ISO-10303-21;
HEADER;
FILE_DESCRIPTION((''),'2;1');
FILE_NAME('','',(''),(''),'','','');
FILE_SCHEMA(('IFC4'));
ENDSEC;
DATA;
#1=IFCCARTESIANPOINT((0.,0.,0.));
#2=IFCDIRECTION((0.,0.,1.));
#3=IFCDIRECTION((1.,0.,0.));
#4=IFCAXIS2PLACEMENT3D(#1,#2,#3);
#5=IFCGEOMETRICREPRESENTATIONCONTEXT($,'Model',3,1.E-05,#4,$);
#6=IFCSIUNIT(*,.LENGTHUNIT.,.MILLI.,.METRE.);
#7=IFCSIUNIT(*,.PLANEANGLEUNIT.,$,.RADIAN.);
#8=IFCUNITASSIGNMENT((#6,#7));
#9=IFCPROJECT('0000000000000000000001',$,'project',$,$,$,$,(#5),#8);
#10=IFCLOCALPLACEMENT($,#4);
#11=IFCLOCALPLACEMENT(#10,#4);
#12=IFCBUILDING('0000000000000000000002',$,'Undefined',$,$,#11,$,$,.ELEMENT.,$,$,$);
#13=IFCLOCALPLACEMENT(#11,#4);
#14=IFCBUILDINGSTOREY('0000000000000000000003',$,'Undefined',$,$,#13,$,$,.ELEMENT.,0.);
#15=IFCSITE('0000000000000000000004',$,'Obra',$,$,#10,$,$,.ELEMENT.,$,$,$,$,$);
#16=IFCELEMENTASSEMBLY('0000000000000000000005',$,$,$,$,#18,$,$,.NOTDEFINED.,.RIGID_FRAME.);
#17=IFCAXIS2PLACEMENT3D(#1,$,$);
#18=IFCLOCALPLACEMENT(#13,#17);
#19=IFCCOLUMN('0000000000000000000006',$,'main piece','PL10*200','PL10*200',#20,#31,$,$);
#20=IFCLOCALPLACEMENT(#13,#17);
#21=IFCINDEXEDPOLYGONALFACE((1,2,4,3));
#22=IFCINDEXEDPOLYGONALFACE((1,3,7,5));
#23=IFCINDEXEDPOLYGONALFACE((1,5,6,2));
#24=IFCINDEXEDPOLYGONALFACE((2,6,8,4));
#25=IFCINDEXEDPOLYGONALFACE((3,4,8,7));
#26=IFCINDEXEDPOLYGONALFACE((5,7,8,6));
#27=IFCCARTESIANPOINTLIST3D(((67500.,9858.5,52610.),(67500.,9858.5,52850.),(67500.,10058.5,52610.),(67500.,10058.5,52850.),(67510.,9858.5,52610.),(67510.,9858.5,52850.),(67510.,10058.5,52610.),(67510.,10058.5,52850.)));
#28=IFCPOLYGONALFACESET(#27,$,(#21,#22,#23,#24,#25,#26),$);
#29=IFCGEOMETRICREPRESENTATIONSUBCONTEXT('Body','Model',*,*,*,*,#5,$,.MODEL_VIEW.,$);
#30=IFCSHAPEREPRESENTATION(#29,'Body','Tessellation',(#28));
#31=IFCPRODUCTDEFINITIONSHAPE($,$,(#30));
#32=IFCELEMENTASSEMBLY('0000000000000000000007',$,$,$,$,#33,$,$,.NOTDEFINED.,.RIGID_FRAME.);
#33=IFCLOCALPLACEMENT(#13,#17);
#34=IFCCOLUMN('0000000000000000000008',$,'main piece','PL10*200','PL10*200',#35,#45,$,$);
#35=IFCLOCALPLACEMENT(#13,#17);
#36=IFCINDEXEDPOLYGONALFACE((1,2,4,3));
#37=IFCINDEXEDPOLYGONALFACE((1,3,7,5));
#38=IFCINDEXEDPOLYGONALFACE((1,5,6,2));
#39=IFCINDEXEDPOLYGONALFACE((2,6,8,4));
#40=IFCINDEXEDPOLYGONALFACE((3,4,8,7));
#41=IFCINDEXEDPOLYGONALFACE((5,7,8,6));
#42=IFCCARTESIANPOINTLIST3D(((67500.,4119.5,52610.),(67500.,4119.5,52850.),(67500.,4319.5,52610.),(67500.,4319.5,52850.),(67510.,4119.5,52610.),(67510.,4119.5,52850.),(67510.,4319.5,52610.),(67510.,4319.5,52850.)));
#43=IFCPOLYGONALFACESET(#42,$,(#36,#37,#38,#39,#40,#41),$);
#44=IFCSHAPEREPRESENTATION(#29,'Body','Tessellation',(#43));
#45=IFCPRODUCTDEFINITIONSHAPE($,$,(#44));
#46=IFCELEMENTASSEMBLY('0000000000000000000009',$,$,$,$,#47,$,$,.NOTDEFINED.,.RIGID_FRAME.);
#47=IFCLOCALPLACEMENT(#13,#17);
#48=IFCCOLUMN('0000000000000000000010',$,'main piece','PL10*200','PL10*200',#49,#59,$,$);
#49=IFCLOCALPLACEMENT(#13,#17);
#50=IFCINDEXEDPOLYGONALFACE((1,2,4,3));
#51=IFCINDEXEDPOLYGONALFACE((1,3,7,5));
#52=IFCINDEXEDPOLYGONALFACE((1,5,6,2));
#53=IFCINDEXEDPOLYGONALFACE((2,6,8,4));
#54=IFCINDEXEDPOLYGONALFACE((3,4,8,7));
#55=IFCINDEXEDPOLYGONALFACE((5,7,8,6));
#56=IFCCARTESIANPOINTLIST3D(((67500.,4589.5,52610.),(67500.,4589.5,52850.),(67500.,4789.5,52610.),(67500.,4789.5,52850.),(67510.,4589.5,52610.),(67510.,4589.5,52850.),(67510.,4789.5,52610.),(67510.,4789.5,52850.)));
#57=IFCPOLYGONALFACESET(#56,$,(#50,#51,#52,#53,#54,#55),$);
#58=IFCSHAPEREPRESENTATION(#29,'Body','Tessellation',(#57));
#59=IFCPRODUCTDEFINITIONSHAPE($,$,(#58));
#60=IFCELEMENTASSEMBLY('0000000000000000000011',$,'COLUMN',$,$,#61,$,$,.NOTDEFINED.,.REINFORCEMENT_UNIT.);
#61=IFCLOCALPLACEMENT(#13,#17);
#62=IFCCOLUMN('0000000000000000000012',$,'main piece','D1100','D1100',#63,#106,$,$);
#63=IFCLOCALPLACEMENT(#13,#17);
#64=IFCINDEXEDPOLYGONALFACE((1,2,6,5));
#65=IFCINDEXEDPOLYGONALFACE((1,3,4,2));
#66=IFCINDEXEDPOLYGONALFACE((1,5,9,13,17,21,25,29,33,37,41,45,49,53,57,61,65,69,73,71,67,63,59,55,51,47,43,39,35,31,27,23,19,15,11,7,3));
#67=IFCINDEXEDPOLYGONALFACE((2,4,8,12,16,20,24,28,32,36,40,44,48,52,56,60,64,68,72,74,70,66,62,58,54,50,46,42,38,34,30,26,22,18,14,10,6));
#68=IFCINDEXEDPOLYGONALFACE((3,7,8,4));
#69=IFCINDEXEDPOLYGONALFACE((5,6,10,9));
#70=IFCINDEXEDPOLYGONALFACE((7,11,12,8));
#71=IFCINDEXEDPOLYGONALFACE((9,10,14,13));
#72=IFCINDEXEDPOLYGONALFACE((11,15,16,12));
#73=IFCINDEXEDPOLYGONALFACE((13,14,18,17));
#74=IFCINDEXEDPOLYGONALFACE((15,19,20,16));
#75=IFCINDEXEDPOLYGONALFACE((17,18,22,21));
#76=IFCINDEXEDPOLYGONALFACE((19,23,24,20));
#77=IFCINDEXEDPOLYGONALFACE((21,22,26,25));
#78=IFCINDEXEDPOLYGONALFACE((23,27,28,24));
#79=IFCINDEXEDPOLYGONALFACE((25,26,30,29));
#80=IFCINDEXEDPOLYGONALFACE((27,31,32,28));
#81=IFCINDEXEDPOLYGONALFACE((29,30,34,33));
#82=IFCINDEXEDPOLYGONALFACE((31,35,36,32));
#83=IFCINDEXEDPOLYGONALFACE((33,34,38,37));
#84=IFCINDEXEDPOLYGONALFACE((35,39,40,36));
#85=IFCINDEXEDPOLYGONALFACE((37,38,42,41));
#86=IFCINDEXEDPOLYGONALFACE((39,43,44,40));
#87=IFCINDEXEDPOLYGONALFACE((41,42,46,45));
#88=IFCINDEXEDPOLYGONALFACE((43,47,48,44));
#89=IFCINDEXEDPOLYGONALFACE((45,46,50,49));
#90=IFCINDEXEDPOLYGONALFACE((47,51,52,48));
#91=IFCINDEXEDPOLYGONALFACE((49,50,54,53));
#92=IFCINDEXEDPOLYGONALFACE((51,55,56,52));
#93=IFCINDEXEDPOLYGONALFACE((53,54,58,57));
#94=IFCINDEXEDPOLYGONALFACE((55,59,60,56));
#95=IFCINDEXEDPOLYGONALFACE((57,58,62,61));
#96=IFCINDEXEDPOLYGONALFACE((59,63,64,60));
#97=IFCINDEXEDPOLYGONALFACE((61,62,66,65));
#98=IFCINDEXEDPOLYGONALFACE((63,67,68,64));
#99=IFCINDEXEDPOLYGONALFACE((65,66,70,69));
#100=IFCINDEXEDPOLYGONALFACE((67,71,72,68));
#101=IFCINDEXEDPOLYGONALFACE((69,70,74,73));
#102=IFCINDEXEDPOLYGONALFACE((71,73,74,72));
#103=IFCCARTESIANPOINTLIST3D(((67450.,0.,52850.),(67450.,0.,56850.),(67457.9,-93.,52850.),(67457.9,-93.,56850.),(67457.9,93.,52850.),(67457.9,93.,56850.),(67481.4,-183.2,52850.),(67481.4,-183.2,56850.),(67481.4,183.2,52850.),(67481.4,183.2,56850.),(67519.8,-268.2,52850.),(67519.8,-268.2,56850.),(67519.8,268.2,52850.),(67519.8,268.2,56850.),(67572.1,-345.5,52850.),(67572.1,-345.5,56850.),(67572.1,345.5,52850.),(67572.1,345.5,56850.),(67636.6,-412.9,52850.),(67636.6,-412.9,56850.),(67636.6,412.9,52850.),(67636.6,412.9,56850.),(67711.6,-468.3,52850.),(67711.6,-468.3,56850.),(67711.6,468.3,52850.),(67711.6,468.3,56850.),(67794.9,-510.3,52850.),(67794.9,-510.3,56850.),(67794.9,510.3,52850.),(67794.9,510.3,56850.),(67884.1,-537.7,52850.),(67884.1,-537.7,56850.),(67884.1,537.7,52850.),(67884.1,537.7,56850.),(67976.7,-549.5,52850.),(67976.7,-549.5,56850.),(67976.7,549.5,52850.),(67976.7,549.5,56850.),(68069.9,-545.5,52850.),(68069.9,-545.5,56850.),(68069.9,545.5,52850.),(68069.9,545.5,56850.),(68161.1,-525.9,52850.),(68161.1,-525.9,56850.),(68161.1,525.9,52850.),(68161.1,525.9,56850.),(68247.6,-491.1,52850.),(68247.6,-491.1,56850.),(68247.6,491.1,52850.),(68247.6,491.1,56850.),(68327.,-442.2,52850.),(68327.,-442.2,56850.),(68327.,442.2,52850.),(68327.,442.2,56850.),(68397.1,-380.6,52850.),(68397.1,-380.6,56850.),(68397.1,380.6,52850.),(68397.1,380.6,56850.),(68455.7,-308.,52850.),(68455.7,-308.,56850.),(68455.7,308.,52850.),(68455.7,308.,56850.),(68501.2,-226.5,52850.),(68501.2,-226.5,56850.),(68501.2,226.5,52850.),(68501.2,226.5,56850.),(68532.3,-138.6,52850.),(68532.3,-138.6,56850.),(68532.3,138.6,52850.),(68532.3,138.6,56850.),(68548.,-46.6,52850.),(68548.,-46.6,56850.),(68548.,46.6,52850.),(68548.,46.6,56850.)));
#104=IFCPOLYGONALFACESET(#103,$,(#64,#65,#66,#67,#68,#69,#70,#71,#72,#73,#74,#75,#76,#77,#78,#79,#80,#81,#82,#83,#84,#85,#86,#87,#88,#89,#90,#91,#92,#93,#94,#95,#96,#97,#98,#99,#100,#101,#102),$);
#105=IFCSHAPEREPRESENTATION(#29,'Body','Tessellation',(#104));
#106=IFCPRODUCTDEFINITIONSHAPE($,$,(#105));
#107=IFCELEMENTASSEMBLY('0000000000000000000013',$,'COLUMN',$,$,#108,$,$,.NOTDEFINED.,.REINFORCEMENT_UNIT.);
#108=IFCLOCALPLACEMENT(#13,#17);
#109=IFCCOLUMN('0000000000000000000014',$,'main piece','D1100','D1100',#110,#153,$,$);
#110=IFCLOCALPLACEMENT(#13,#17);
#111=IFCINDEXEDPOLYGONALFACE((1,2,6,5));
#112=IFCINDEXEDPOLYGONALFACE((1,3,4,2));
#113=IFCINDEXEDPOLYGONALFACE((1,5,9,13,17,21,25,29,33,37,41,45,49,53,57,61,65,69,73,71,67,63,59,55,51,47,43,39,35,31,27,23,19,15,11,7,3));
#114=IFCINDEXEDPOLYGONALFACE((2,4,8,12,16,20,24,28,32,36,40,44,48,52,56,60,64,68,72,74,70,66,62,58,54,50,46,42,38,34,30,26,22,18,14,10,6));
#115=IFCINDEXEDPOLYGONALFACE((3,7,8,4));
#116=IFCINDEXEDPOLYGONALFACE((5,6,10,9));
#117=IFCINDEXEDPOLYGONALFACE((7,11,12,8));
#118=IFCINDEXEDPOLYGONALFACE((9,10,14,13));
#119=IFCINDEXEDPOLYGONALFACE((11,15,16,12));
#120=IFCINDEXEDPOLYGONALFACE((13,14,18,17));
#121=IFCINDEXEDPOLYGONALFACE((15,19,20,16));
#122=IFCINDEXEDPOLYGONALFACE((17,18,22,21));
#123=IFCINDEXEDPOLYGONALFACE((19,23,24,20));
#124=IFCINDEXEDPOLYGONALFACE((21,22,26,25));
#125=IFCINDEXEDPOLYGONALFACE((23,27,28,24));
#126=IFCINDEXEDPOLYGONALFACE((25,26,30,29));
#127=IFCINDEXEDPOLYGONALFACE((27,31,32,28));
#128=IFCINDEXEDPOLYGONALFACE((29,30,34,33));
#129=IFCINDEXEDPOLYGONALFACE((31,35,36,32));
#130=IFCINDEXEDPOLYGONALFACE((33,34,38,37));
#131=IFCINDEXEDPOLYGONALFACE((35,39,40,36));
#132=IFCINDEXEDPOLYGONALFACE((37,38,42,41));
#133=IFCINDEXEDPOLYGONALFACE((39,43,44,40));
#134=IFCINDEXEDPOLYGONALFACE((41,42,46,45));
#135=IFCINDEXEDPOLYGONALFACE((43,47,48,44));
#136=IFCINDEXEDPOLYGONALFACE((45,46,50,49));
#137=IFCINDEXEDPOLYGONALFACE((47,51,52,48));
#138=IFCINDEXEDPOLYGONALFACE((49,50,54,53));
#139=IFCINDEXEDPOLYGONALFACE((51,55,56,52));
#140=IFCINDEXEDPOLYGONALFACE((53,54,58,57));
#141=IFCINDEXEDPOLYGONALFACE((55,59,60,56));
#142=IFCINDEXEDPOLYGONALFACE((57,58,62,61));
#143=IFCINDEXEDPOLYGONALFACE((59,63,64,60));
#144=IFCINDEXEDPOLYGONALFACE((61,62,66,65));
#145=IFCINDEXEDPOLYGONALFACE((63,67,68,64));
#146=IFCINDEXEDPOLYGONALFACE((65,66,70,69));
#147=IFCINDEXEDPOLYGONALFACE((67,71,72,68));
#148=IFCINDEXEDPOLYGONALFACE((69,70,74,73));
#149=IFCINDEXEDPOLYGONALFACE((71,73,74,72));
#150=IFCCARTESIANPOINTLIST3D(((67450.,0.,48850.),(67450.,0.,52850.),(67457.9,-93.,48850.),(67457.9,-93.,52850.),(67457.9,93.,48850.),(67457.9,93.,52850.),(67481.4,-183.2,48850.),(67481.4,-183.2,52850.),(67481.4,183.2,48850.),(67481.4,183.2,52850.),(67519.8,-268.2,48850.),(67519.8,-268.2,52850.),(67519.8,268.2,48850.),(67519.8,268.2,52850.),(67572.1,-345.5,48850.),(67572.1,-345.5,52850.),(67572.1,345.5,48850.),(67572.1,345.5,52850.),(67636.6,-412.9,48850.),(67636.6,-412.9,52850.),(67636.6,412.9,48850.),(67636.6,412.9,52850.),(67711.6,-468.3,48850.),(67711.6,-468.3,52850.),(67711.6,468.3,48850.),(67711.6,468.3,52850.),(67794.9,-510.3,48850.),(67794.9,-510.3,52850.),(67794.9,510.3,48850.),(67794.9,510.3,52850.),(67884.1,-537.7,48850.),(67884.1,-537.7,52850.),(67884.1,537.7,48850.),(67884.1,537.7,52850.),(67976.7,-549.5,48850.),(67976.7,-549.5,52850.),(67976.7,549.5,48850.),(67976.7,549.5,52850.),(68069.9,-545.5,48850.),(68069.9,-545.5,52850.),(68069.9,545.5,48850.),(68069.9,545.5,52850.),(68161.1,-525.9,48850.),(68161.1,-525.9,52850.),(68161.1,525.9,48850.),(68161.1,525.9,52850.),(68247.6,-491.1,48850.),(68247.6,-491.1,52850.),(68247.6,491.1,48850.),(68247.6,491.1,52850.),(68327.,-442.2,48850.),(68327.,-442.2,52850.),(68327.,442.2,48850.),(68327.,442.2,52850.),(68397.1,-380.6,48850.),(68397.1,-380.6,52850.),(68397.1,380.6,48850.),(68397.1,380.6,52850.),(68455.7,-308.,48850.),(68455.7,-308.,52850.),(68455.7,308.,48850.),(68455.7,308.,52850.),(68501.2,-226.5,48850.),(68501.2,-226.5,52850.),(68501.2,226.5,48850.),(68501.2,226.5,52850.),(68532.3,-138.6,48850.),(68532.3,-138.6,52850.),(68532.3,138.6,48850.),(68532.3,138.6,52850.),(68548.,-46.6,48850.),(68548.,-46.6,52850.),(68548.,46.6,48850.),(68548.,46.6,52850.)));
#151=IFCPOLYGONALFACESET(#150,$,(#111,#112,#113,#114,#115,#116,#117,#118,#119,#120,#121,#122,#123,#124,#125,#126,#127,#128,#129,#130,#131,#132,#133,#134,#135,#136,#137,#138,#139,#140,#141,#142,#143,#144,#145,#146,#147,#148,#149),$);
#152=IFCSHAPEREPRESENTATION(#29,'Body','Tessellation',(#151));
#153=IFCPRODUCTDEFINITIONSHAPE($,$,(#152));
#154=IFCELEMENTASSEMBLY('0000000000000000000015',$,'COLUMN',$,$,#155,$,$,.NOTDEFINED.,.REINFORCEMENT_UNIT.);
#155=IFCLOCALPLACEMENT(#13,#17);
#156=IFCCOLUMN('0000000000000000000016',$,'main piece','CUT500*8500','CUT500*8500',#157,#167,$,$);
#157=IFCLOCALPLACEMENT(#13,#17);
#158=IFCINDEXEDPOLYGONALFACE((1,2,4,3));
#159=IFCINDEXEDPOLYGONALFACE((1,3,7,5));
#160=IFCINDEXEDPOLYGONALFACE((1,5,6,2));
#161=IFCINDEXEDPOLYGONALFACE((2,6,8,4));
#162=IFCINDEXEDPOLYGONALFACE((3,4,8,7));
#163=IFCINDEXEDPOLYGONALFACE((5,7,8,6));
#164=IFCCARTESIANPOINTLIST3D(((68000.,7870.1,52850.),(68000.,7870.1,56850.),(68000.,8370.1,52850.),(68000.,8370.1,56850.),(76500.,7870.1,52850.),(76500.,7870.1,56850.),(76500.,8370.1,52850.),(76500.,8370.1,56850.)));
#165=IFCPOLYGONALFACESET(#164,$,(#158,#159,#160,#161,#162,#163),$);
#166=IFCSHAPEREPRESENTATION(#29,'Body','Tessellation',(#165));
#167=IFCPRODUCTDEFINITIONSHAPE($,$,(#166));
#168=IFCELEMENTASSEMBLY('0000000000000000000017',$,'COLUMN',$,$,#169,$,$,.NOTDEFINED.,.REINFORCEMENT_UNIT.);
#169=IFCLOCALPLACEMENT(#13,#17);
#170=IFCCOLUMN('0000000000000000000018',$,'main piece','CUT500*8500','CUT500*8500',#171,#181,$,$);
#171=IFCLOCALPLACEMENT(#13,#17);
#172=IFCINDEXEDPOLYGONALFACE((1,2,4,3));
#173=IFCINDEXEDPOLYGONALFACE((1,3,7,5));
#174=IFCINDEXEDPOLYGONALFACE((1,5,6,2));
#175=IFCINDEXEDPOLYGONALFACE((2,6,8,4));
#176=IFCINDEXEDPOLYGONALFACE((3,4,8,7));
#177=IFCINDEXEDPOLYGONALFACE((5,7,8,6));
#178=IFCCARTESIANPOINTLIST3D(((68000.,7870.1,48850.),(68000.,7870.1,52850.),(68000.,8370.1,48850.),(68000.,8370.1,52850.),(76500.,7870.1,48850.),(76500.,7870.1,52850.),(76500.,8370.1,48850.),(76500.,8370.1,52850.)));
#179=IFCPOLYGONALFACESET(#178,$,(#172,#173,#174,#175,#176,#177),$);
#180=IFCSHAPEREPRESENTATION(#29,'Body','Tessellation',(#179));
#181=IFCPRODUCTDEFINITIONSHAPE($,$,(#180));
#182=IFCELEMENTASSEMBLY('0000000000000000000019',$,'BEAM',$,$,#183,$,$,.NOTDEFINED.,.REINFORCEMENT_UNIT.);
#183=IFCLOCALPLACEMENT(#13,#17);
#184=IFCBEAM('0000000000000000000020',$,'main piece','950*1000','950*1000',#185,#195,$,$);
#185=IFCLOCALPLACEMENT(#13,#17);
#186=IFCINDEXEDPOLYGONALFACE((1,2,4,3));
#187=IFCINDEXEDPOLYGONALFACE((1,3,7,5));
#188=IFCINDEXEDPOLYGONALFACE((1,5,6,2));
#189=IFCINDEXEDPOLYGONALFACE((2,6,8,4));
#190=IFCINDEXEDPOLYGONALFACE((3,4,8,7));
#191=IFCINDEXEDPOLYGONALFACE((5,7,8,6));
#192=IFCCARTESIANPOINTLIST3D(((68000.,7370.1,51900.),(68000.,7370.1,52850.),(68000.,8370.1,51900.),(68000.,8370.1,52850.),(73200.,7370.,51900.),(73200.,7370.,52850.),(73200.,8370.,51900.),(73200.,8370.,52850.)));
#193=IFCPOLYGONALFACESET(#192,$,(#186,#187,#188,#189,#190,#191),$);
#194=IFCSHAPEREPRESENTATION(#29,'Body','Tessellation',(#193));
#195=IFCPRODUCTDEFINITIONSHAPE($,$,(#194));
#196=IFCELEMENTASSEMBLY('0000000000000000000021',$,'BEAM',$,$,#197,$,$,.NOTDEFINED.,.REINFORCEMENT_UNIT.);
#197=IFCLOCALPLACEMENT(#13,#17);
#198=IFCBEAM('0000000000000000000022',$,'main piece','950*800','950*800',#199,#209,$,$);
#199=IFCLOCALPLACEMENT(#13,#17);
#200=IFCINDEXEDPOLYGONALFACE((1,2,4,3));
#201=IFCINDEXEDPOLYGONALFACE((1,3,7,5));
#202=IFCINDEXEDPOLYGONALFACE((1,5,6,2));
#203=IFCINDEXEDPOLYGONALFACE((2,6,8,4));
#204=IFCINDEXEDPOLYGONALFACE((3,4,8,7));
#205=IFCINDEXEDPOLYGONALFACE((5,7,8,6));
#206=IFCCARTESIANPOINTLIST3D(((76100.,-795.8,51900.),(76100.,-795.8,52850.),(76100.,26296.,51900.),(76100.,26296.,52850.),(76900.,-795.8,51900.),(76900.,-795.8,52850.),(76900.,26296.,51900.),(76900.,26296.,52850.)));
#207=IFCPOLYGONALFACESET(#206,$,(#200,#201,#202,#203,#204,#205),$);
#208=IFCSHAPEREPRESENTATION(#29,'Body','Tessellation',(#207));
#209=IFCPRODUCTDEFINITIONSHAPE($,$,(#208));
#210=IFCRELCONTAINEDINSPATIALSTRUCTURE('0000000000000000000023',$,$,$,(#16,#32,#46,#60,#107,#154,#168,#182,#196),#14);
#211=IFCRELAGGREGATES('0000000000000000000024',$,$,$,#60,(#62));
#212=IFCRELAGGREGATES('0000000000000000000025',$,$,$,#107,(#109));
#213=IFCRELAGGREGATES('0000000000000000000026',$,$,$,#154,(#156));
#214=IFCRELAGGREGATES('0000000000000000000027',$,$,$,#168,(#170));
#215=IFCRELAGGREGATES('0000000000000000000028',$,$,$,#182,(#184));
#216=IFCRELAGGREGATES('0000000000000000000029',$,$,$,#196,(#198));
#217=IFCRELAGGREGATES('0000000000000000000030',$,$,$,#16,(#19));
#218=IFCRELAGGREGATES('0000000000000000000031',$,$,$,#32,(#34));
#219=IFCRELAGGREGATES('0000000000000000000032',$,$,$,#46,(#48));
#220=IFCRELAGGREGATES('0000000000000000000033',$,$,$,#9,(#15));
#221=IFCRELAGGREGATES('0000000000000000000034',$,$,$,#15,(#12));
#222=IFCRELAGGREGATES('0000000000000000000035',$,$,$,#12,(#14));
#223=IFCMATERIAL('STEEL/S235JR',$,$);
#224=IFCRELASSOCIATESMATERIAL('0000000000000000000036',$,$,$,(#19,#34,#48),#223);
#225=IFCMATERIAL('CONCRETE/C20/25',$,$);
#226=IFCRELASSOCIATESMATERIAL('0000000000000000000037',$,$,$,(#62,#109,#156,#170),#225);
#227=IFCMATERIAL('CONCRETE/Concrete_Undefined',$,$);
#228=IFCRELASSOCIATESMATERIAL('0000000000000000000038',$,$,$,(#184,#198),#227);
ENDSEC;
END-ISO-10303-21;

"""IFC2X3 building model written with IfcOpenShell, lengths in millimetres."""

from ifc_helpers import new_model, si_unit, frame, origin_with_axes, origin_2d_with_axis, place, context, subcontext, project, spatial, rectangle, circle, extrude, material, element, aggregate, save


model = new_model("IFC2X3")

# Units and contexts
model_context = context("Model", 3, precision=1e-05, world=origin_with_axes())
body_context = subcontext(model_context, "Body", "Model", "MODEL_VIEW")
ifc_project = project(units=[si_unit("LENGTHUNIT", "METRE", prefix="MILLI"), si_unit("PLANEANGLEUNIT", "RADIAN")], contexts=[model_context])

# Site, building, storey
site_placement = place(None, origin_with_axes())
site = spatial("IfcSite", under=ifc_project, at=site_placement, Name="Obra", CompositionType="ELEMENT")
building_placement = place(site_placement, origin_with_axes())
building = spatial("IfcBuilding", under=site, at=building_placement, Name="Undefined", CompositionType="ELEMENT")
storey_placement = place(building_placement, origin_with_axes())
storey = spatial("IfcBuildingStorey", under=building, at=storey_placement, Name="Undefined", CompositionType="ELEMENT", Elevation=0.0)

# Element assemblies, columns
assembly_1_placement = place(storey_placement, origin_with_axes())
assembly_1 = element("IfcElementAssembly", 1, at=assembly_1_placement, inside=storey, AssemblyPlace="NOTDEFINED", PredefinedType="RIGID_FRAME")
ifc_material_1 = material(Name="STEEL/S235JR")
column_1_placement = place(assembly_1_placement, frame((67505.0, 9958.5, 52610.0), z_axis=(0.0, 0.0, 1.0), x_axis=(0.0, 1.0, 0.0)))
column_1 = element("IfcColumn", 2, at=column_1_placement, material=ifc_material_1, Name="main piece", Description="PL10*200", ObjectType="PL10*200", context=body_context, shape_type="SweptSolid", body=[
    extrude(rectangle(XDim=10.0, YDim=200.0, at=origin_2d_with_axis()), frame((0.0, 0.0, 240.0), z_axis=(0.0, 0.0, -1.0), x_axis=(0.0, 1.0, 0.0)), (0.0, 0.0, 1.0), 240.0),
])
assembly_2_placement = place(storey_placement, origin_with_axes())
assembly_2 = element("IfcElementAssembly", 3, at=assembly_2_placement, inside=storey, AssemblyPlace="NOTDEFINED", PredefinedType="RIGID_FRAME")
column_2_placement = place(assembly_2_placement, frame((67505.0, 4219.5, 52610.0), z_axis=(0.0, 0.0, 1.0), x_axis=(0.0, 1.0, 0.0)))
column_2 = element("IfcColumn", 4, at=column_2_placement, material=ifc_material_1, Name="main piece", Description="PL10*200", ObjectType="PL10*200", context=body_context, shape_type="SweptSolid", body=[
    extrude(rectangle(XDim=10.0, YDim=200.0, at=origin_2d_with_axis()), frame((0.0, 0.0, 240.0), z_axis=(0.0, 0.0, -1.0), x_axis=(0.0, 1.0, 0.0)), (0.0, 0.0, 1.0), 240.0),
])
assembly_3_placement = place(storey_placement, origin_with_axes())
assembly_3 = element("IfcElementAssembly", 5, at=assembly_3_placement, inside=storey, AssemblyPlace="NOTDEFINED", PredefinedType="RIGID_FRAME")
column_3_placement = place(assembly_3_placement, frame((67505.0, 4689.5, 52610.0), z_axis=(0.0, 0.0, 1.0), x_axis=(0.0, 1.0, 0.0)))
column_3 = element("IfcColumn", 6, at=column_3_placement, material=ifc_material_1, Name="main piece", Description="PL10*200", ObjectType="PL10*200", context=body_context, shape_type="SweptSolid", body=[
    extrude(rectangle(XDim=10.0, YDim=200.0, at=origin_2d_with_axis()), frame((0.0, 0.0, 240.0), z_axis=(0.0, 0.0, -1.0), x_axis=(0.0, 1.0, 0.0)), (0.0, 0.0, 1.0), 240.0),
])
assembly_4_placement = place(storey_placement, origin_with_axes())
assembly_4 = element("IfcElementAssembly", 7, at=assembly_4_placement, inside=storey, Name="COLUMN", AssemblyPlace="NOTDEFINED", PredefinedType="REINFORCEMENT_UNIT")
ifc_material_2 = material(Name="CONCRETE/C20/25")
column_4_placement = place(assembly_4_placement, frame((68000.0, 0.0, 52850.0), z_axis=(0.0, 0.0, 1.0), x_axis=(0.0, 1.0, 0.0)))
column_4 = element("IfcColumn", 8, at=column_4_placement, material=ifc_material_2, Name="main piece", Description="D1100", ObjectType="D1100", context=body_context, shape_type="SweptSolid", body=[
    extrude(circle(Radius=550.0, at=origin_2d_with_axis()), frame((0.0, 0.0, 4000.0), z_axis=(0.0, 0.0, -1.0), x_axis=(0.0, 1.0, 0.0)), (0.0, 0.0, 1.0), 4000.0),
])
aggregate(assembly_4, [column_4])
assembly_5_placement = place(storey_placement, origin_with_axes())
assembly_5 = element("IfcElementAssembly", 9, at=assembly_5_placement, inside=storey, Name="COLUMN", AssemblyPlace="NOTDEFINED", PredefinedType="REINFORCEMENT_UNIT")
column_5_placement = place(assembly_5_placement, frame((68000.0, 0.0, 48850.0), z_axis=(0.0, 0.0, 1.0), x_axis=(0.0, 1.0, 0.0)))
column_5 = element("IfcColumn", 10, at=column_5_placement, material=ifc_material_2, Name="main piece", Description="D1100", ObjectType="D1100", context=body_context, shape_type="SweptSolid", body=[
    extrude(circle(Radius=550.0, at=origin_2d_with_axis()), frame((0.0, 0.0, 4000.0), z_axis=(0.0, 0.0, -1.0), x_axis=(0.0, 1.0, 0.0)), (0.0, 0.0, 1.0), 4000.0),
])
aggregate(assembly_5, [column_5])
assembly_6_placement = place(storey_placement, origin_with_axes())
assembly_6 = element("IfcElementAssembly", 11, at=assembly_6_placement, inside=storey, Name="COLUMN", AssemblyPlace="NOTDEFINED", PredefinedType="REINFORCEMENT_UNIT")
column_6_placement = place(assembly_6_placement, frame((72250.0, 8120.1, 52850.0), z_axis=(0.0, 0.0, 1.0), x_axis=(-1.0, 0.0, 0.0)))
column_6 = element("IfcColumn", 12, at=column_6_placement, material=ifc_material_2, Name="main piece", Description="CUT500*8500", ObjectType="CUT500*8500", context=body_context, shape_type="SweptSolid", body=[
    extrude(rectangle(XDim=500.0, YDim=8500.0, at=origin_2d_with_axis()), frame((0.0, 0.0, 4000.0), z_axis=(0.0, 0.0, -1.0), x_axis=(0.0, 1.0, 0.0)), (0.0, 0.0, 1.0), 4000.0),
])
aggregate(assembly_6, [column_6])
assembly_7_placement = place(storey_placement, origin_with_axes())
assembly_7 = element("IfcElementAssembly", 13, at=assembly_7_placement, inside=storey, Name="COLUMN", AssemblyPlace="NOTDEFINED", PredefinedType="REINFORCEMENT_UNIT")
column_7_placement = place(assembly_7_placement, frame((72250.0, 8120.1, 48850.0), z_axis=(0.0, 0.0, 1.0), x_axis=(-1.0, 0.0, 0.0)))
column_7 = element("IfcColumn", 14, at=column_7_placement, material=ifc_material_2, Name="main piece", Description="CUT500*8500", ObjectType="CUT500*8500", context=body_context, shape_type="SweptSolid", body=[
    extrude(rectangle(XDim=500.0, YDim=8500.0, at=origin_2d_with_axis()), frame((0.0, 0.0, 4000.0), z_axis=(0.0, 0.0, -1.0), x_axis=(0.0, 1.0, 0.0)), (0.0, 0.0, 1.0), 4000.0),
])
aggregate(assembly_7, [column_7])

# Element assemblies, beams
assembly_8_placement = place(storey_placement, origin_with_axes())
assembly_8 = element("IfcElementAssembly", 15, at=assembly_8_placement, inside=storey, Name="BEAM", AssemblyPlace="NOTDEFINED", PredefinedType="REINFORCEMENT_UNIT")
ifc_material_3 = material(Name="CONCRETE/Concrete_Undefined")
beam_1_placement = place(assembly_8_placement, frame((68000.0, 7870.1, 52375.0), z_axis=(0.0, 0.0, 1.0), x_axis=(1.0, -0.000019, 0.0)))
beam_1 = element("IfcBeam", 16, at=beam_1_placement, material=ifc_material_3, Name="main piece", Description="950*1000", ObjectType="950*1000", context=body_context, shape_type="SweptSolid", body=[
    extrude(rectangle(XDim=1000.0, YDim=950.0, at=origin_2d_with_axis()), frame((5200.0, 0.0, 0.0), z_axis=(-1.0, 0.0, 0.0), x_axis=(0.0, -1.0, 0.0)), (0.0, 0.0, 1.0), 5200.0),
])
aggregate(assembly_8, [beam_1])
assembly_9_placement = place(storey_placement, origin_with_axes())
assembly_9 = element("IfcElementAssembly", 17, at=assembly_9_placement, inside=storey, Name="BEAM", AssemblyPlace="NOTDEFINED", PredefinedType="REINFORCEMENT_UNIT")
beam_2_placement = place(assembly_9_placement, frame((76500.0, -795.8, 52375.0), z_axis=(0.0, 0.0, 1.0), x_axis=(0.0, 1.0, 0.0)))
beam_2 = element("IfcBeam", 18, at=beam_2_placement, material=ifc_material_3, Name="main piece", Description="950*800", ObjectType="950*800", context=body_context, shape_type="SweptSolid", body=[
    extrude(rectangle(XDim=800.0, YDim=950.0, at=origin_2d_with_axis()), frame((27091.8, 0.0, 0.0), z_axis=(-1.0, 0.0, 0.0), x_axis=(0.0, -1.0, 0.0)), (0.0, 0.0, 1.0), 27091.8),
])
aggregate(assembly_9, [beam_2])

aggregate(assembly_1, [column_1])
aggregate(assembly_2, [column_2])
aggregate(assembly_3, [column_3])

save(model, "model.ifc")
